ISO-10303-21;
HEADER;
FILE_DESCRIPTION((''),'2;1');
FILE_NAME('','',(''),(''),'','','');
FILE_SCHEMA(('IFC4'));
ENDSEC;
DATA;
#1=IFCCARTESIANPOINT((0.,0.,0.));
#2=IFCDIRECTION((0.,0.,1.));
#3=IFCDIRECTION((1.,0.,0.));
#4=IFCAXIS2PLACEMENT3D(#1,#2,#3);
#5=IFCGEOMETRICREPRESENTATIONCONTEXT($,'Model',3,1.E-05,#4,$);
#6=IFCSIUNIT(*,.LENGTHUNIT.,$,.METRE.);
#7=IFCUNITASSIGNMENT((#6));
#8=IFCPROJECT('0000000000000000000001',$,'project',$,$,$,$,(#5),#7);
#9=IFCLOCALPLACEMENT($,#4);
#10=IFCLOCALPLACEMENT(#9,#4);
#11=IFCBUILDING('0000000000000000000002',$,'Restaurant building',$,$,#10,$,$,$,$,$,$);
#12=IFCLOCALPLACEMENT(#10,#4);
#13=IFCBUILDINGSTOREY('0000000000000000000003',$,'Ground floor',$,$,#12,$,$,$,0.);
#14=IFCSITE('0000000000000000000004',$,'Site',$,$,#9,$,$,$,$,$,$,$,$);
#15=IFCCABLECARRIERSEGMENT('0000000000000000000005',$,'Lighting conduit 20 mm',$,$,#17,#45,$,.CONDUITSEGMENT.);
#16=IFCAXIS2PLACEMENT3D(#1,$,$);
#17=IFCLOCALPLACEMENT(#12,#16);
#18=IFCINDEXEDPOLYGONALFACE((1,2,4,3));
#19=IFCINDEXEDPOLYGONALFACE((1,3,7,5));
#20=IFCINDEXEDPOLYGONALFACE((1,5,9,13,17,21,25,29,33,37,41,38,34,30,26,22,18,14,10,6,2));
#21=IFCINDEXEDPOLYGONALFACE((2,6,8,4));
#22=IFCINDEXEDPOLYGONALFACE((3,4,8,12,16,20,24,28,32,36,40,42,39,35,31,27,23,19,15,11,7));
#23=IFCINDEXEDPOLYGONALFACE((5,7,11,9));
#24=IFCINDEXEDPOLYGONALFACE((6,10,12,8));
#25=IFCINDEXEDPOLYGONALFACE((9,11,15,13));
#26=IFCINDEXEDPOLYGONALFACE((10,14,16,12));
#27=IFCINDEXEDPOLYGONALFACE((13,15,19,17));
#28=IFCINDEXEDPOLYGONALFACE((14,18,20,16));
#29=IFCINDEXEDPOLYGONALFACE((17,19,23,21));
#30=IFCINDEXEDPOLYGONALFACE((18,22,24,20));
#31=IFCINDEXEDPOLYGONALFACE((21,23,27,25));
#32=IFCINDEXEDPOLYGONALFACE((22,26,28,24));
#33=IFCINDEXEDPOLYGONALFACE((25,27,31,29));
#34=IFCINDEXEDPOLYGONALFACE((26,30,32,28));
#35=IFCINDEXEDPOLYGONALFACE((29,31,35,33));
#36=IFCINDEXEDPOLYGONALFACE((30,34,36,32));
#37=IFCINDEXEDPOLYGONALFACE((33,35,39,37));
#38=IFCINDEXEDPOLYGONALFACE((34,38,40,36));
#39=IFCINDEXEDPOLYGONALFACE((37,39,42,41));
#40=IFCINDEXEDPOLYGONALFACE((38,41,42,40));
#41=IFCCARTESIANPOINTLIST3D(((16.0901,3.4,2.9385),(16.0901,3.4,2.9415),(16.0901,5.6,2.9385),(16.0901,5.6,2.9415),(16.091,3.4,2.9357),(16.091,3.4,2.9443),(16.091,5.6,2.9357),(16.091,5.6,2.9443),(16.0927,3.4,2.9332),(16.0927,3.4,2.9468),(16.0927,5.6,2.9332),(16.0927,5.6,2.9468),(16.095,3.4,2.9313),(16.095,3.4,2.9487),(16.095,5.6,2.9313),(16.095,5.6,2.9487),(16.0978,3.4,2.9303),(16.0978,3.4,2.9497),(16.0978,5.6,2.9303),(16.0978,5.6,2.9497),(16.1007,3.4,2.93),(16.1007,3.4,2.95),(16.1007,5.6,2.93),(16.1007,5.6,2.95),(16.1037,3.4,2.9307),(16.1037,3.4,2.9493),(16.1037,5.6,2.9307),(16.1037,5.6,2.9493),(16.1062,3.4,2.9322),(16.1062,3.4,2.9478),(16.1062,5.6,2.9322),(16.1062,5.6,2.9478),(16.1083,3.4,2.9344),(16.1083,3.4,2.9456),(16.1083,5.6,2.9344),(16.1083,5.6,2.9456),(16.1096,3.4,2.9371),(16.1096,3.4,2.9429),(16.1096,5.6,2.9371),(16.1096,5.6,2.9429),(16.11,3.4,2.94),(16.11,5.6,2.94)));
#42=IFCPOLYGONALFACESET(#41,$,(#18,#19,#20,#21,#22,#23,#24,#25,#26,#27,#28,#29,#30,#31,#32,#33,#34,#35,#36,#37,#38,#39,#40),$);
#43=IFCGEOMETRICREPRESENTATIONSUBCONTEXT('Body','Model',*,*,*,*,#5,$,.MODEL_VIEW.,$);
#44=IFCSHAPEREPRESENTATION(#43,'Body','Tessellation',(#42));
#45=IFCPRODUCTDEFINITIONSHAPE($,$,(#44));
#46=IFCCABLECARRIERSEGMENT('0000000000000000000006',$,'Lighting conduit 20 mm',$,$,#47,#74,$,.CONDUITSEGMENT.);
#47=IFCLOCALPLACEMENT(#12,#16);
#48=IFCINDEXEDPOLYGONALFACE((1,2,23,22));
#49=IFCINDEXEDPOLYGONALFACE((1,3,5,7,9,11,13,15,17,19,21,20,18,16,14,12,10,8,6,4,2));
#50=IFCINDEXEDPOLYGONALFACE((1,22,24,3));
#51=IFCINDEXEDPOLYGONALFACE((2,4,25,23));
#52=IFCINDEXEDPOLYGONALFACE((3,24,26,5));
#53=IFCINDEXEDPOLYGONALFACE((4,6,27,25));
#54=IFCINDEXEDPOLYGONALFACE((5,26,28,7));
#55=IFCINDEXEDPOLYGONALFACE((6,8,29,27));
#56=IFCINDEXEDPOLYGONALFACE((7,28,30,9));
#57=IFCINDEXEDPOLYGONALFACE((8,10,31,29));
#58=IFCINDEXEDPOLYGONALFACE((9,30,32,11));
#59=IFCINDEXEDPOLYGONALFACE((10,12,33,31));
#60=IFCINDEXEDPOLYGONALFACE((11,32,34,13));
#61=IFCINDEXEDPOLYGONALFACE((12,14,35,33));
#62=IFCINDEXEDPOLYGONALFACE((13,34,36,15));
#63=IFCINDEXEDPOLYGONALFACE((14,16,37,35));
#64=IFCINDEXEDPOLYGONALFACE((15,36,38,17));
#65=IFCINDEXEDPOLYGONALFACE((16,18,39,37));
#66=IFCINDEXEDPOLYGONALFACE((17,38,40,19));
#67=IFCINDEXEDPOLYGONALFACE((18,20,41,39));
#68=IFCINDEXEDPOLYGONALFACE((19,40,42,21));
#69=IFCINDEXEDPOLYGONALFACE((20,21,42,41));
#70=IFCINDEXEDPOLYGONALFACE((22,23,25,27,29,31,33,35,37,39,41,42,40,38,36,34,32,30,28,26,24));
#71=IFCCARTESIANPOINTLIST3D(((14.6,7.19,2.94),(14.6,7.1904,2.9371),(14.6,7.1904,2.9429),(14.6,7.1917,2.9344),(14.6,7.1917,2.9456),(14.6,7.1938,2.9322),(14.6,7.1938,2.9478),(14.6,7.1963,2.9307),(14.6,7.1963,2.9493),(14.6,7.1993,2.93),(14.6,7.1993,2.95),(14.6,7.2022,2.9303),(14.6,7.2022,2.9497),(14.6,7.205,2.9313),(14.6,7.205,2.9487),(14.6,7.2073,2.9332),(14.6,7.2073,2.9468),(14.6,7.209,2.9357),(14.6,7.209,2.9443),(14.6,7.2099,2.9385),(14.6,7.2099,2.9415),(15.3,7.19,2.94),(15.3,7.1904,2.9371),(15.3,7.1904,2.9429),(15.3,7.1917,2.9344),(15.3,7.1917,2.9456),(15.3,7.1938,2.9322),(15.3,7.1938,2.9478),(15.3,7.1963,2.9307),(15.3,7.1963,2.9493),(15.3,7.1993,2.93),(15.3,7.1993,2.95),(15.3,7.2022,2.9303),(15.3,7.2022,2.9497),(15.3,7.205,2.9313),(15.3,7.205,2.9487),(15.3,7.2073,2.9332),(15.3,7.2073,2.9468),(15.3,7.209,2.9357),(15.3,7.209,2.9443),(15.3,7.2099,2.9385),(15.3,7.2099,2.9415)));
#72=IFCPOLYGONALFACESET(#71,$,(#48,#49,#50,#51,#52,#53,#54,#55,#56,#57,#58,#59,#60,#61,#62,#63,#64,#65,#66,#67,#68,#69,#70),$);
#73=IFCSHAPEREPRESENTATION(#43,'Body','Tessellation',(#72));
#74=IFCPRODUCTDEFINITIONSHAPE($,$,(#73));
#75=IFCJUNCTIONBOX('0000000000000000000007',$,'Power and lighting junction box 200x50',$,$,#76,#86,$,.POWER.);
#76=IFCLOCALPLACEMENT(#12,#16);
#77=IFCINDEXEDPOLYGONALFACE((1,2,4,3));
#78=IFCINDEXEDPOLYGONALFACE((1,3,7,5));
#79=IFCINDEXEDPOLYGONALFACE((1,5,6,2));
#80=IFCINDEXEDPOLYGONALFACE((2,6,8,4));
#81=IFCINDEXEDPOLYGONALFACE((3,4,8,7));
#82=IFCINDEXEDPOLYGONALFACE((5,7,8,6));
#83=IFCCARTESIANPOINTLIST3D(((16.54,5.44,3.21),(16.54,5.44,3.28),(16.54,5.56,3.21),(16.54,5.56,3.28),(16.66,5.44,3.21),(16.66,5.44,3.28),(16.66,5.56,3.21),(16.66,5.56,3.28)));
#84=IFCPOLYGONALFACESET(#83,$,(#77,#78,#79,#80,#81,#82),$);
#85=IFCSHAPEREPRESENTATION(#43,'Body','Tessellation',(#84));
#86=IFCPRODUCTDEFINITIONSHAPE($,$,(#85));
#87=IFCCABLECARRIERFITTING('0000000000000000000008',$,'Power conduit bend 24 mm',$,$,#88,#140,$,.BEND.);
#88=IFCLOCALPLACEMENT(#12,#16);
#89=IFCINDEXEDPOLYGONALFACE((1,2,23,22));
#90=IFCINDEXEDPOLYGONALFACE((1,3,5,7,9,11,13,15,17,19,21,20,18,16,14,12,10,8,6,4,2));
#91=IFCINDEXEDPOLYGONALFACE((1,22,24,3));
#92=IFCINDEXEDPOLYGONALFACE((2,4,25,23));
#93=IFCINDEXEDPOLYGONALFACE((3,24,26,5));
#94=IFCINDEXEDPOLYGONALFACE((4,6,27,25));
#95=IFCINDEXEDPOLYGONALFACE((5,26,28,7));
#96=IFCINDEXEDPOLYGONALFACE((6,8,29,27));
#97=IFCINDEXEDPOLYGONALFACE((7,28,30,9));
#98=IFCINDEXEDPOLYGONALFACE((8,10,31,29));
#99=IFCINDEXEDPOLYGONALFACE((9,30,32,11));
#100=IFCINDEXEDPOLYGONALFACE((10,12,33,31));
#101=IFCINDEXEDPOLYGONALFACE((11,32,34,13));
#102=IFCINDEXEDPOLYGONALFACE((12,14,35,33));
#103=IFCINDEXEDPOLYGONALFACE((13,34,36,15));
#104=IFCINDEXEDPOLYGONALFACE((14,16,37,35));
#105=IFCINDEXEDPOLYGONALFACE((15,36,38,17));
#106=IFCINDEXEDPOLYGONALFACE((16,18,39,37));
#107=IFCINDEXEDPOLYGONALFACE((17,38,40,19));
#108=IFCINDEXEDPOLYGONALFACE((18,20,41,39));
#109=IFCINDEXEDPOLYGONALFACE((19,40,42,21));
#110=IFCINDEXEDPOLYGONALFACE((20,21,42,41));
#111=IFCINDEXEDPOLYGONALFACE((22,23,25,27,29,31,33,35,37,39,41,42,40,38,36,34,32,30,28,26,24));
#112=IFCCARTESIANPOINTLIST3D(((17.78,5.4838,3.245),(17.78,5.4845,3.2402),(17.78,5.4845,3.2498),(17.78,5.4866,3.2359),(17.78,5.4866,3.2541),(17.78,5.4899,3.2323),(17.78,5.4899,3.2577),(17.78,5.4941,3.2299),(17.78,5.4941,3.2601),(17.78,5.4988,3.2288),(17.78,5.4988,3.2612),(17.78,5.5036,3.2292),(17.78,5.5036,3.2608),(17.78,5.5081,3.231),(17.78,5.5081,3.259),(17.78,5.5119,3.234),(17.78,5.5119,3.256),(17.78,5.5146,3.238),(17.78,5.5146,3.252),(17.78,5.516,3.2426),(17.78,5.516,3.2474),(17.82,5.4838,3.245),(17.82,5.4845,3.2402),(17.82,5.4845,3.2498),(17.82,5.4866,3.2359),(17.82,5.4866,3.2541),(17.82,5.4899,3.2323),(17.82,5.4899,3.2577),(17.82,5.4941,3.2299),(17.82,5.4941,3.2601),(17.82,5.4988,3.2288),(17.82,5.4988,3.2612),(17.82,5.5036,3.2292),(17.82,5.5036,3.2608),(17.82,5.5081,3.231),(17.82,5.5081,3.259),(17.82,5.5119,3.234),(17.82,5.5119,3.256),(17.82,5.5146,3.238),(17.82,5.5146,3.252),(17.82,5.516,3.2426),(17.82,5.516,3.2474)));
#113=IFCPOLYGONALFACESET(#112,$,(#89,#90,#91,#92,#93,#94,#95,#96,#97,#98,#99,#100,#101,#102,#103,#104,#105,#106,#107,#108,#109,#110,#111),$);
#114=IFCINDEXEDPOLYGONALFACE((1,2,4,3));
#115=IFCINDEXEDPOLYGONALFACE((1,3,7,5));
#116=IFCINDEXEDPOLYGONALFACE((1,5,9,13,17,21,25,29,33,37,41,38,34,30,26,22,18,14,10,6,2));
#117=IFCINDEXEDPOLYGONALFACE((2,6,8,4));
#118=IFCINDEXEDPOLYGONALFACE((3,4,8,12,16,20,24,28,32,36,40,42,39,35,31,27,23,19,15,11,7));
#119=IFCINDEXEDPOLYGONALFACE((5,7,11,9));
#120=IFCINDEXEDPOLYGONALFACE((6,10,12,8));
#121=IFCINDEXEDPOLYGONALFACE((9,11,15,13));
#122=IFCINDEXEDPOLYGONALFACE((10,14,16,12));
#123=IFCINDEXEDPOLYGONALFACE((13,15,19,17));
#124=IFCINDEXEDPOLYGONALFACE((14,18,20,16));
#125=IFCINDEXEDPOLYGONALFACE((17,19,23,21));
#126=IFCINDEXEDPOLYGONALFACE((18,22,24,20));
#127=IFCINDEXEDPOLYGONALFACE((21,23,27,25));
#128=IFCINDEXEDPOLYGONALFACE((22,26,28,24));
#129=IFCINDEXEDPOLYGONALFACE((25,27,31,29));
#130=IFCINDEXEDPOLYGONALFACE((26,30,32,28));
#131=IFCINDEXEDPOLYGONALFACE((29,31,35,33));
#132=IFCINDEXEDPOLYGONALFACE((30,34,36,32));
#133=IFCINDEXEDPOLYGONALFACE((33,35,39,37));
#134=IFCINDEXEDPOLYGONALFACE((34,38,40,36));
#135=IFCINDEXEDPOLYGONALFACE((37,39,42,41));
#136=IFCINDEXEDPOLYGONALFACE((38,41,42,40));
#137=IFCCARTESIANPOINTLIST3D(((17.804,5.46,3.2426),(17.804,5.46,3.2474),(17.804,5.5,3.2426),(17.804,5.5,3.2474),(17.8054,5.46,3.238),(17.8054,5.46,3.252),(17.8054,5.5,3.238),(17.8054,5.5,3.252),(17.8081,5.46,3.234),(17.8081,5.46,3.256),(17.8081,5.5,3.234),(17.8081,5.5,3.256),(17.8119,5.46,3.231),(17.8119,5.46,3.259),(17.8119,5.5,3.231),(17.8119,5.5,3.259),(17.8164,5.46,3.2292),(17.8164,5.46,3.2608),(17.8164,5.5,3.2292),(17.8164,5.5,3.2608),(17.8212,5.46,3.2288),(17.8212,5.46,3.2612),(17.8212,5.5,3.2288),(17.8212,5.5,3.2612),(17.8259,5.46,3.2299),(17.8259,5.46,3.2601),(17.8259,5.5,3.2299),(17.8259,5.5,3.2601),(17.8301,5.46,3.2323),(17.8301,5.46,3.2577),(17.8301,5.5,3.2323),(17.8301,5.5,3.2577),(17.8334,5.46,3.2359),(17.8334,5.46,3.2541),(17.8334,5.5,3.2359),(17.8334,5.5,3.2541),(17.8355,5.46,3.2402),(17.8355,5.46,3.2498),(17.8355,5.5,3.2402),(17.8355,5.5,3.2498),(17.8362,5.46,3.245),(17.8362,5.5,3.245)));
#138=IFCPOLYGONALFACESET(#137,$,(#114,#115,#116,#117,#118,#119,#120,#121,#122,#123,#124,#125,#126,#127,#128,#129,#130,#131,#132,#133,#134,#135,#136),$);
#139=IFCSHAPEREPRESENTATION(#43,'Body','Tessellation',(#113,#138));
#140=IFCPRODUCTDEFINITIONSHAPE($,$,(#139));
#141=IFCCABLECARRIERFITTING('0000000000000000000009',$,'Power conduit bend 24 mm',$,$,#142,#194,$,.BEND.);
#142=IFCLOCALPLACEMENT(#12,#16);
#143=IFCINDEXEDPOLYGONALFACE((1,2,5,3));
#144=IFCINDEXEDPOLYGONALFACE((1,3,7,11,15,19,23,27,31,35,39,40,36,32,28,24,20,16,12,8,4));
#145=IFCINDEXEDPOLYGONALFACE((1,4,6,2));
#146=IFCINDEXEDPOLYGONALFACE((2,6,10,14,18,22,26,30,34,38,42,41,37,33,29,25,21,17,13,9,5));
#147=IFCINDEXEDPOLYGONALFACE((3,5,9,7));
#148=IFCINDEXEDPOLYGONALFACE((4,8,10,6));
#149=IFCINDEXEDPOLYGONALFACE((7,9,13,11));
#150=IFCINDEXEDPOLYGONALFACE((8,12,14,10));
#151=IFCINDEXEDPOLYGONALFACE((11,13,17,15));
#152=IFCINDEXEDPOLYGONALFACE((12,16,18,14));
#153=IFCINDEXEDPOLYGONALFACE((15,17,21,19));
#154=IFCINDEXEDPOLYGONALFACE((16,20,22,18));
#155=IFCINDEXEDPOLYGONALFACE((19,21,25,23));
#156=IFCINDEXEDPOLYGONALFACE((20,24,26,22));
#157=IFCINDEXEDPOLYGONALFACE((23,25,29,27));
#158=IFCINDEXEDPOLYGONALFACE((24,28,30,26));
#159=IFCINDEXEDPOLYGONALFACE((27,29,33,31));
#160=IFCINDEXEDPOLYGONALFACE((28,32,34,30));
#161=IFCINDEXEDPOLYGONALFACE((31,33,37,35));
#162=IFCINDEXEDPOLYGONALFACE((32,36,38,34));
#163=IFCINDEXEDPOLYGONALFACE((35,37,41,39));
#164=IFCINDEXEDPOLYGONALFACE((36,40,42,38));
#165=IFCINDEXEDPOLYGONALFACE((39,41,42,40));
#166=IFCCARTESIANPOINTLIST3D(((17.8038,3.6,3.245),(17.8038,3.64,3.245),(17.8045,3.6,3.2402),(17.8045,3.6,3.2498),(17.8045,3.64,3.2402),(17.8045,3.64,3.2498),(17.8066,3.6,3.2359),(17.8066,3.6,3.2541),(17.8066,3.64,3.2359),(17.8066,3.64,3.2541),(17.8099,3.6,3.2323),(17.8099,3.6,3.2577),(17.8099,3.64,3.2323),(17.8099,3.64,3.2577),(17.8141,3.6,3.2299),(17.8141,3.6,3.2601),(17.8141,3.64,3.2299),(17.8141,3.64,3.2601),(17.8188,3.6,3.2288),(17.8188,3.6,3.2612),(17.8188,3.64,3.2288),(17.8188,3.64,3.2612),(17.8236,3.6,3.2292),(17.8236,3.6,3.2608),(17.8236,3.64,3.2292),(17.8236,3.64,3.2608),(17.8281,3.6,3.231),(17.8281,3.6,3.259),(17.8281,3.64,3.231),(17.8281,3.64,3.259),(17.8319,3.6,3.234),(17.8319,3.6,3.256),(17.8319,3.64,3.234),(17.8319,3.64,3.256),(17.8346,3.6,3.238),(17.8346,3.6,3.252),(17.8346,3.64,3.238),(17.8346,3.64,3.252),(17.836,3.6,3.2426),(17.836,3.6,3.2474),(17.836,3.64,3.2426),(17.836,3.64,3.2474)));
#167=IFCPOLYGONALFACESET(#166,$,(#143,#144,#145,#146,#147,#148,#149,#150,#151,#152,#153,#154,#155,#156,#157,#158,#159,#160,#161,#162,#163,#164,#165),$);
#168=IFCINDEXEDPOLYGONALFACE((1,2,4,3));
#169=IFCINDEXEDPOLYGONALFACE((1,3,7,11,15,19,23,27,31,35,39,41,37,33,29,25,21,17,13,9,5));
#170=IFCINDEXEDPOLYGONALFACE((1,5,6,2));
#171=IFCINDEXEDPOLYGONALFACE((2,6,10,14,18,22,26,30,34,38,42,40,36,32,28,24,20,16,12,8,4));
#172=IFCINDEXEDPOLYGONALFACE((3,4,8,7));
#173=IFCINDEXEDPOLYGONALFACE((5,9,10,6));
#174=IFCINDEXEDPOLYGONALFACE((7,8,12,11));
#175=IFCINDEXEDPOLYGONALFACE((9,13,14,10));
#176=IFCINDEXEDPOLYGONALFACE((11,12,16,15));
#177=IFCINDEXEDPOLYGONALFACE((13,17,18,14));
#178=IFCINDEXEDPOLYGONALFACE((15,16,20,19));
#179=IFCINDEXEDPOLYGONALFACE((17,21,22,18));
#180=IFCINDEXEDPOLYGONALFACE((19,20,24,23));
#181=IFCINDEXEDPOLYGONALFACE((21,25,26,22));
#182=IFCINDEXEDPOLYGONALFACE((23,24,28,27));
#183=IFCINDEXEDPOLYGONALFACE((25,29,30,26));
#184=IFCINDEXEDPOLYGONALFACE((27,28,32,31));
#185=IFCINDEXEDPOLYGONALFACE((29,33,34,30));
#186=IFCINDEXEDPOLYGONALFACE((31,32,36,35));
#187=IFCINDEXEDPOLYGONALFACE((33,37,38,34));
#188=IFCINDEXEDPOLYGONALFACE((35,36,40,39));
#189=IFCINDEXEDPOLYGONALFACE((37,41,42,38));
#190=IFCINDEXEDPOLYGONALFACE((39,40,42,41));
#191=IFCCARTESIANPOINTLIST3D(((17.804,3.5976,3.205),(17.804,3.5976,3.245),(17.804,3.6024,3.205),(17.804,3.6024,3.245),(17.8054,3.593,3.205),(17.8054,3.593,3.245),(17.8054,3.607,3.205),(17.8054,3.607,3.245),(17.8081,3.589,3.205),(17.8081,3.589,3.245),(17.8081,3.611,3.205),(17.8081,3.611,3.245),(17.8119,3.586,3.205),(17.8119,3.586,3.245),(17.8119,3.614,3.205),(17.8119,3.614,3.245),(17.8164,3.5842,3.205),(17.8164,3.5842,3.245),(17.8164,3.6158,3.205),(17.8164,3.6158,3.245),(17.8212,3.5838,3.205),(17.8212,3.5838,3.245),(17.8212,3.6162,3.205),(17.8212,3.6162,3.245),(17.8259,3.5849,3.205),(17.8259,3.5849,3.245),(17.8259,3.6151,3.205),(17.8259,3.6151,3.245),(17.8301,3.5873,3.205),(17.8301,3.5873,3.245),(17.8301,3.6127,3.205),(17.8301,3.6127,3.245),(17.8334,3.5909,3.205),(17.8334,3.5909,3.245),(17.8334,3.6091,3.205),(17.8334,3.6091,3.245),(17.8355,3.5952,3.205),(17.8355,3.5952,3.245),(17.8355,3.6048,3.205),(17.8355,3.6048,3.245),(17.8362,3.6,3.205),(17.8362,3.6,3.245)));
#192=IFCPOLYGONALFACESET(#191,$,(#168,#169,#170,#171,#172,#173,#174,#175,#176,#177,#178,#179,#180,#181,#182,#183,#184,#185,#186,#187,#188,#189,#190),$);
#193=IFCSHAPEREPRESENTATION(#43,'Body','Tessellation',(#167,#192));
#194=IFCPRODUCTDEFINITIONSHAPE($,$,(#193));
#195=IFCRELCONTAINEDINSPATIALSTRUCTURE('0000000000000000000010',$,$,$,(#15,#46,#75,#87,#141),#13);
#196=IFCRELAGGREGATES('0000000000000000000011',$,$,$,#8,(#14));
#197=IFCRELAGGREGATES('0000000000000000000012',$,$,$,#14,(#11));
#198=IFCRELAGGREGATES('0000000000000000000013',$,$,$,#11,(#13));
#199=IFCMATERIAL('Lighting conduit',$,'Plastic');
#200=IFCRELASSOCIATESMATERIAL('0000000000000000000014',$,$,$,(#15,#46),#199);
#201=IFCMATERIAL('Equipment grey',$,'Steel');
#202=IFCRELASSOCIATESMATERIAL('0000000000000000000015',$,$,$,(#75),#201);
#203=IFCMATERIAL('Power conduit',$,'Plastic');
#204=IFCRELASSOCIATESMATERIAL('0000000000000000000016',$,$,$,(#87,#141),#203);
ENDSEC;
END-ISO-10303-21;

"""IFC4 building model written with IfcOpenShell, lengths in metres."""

from ifc_helpers import new_model, si_unit, frame, origin_with_axes, origin_2d, place, context, subcontext, project, spatial, rectangle, circle, extrude, material, element, save


model = new_model("IFC4")

# Units and contexts
model_context = context("Model", 3, precision=1e-05, world=origin_with_axes())
body_context = subcontext(model_context, "Body", "Model", "MODEL_VIEW")
ifc_project = project(units=[si_unit("LENGTHUNIT", "METRE")], contexts=[model_context])

# Site, building, storey
site_placement = place(None, origin_with_axes())
site = spatial("IfcSite", under=ifc_project, at=site_placement, Name="Site")
building_placement = place(site_placement, origin_with_axes())
building = spatial("IfcBuilding", under=site, at=building_placement, Name="Restaurant building")
storey_placement = place(building_placement, origin_with_axes())
storey = spatial("IfcBuildingStorey", under=building, at=storey_placement, Name="Ground floor", Elevation=0.0)

# Cable carrier segments
ifc_material_1 = material(Name="Power conduit", Category="Plastic")
ifc_material_2 = material(Name="Lighting conduit", Category="Plastic")
cable_carrier_segment_1_placement = place(storey_placement, frame((16.1, 5.6, 2.94)))
element("IfcCableCarrierSegment", 1, at=cable_carrier_segment_1_placement, inside=storey, material=ifc_material_2, Name="Lighting conduit 20 mm", PredefinedType="CONDUITSEGMENT", context=body_context, shape_type="SweptSolid", body=[
    extrude(circle(Radius=0.01, at=origin_2d()), frame((0.0, 0.0, 0.0), z_axis=(0.0, -1.0, 0.0), x_axis=(1.0, 0.0, 0.0)), (0.0, 0.0, 1.0), 2.2),
])
cable_carrier_segment_2_placement = place(storey_placement, frame((15.3, 7.2, 2.94)))
element("IfcCableCarrierSegment", 2, at=cable_carrier_segment_2_placement, inside=storey, material=ifc_material_2, Name="Lighting conduit 20 mm", PredefinedType="CONDUITSEGMENT", context=body_context, shape_type="SweptSolid", body=[
    extrude(circle(Radius=0.01, at=origin_2d()), frame((0.0, 0.0, 0.0), z_axis=(-1.0, 0.0, 0.0), x_axis=(0.0, -1.0, 0.0)), (0.0, 0.0, 1.0), 0.7),
])

# Junction box
ifc_material_3 = material(Name="Equipment grey", Category="Steel")
junction_box_placement = place(storey_placement, frame((16.6, 5.5, 3.245)))
element("IfcJunctionBox", 3, at=junction_box_placement, inside=storey, material=ifc_material_3, Name="Power and lighting junction box 200x50", PredefinedType="POWER", context=body_context, shape_type="SweptSolid", body=[
    extrude(rectangle(XDim=0.12, YDim=0.12, at=origin_2d()), frame((0.0, 0.0, -0.035)), (0.0, 0.0, 1.0), 0.07),
])

# Cable carrier fittings
cable_carrier_fitting_1_placement = place(storey_placement, frame((17.82, 5.5, 3.245)))
element("IfcCableCarrierFitting", 4, at=cable_carrier_fitting_1_placement, inside=storey, material=ifc_material_1, Name="Power conduit bend 24 mm", PredefinedType="BEND", context=body_context, shape_type="SweptSolid", body=[
    extrude(circle(Radius=0.0162, at=origin_2d()), frame((0.0, 0.0, 0.0), z_axis=(-1.0, 0.0, 0.0), x_axis=(0.0, -1.0, 0.0)), (0.0, 0.0, 1.0), 0.04),
    extrude(circle(Radius=0.0162, at=origin_2d()), frame((0.0, 0.0, 0.0), z_axis=(0.0, -1.0, 0.0), x_axis=(1.0, 0.0, 0.0)), (0.0, 0.0, 1.0), 0.04),
])
for number, where, name in (
    (5, (17.82, 3.6, 3.245), "Power conduit bend 24 mm"),
):
    element("IfcCableCarrierFitting", number, at=place(storey_placement, frame(where)), inside=storey, material=ifc_material_1, Name=name, PredefinedType="BEND", context=body_context, shape_type="SweptSolid", body=[
        extrude(circle(Radius=0.0162, at=origin_2d()), frame((0.0, 0.0, 0.0), z_axis=(0.0, 1.0, 0.0), x_axis=(-1.0, 0.0, 0.0)), (0.0, 0.0, 1.0), 0.04),
        extrude(circle(Radius=0.0162, at=origin_2d()), frame((0.0, 0.0, 0.0), z_axis=(0.0, 0.0, -1.0), x_axis=(1.0, 0.0, 0.0)), (0.0, 0.0, 1.0), 0.04),
    ])

save(model, "model.ifc")
